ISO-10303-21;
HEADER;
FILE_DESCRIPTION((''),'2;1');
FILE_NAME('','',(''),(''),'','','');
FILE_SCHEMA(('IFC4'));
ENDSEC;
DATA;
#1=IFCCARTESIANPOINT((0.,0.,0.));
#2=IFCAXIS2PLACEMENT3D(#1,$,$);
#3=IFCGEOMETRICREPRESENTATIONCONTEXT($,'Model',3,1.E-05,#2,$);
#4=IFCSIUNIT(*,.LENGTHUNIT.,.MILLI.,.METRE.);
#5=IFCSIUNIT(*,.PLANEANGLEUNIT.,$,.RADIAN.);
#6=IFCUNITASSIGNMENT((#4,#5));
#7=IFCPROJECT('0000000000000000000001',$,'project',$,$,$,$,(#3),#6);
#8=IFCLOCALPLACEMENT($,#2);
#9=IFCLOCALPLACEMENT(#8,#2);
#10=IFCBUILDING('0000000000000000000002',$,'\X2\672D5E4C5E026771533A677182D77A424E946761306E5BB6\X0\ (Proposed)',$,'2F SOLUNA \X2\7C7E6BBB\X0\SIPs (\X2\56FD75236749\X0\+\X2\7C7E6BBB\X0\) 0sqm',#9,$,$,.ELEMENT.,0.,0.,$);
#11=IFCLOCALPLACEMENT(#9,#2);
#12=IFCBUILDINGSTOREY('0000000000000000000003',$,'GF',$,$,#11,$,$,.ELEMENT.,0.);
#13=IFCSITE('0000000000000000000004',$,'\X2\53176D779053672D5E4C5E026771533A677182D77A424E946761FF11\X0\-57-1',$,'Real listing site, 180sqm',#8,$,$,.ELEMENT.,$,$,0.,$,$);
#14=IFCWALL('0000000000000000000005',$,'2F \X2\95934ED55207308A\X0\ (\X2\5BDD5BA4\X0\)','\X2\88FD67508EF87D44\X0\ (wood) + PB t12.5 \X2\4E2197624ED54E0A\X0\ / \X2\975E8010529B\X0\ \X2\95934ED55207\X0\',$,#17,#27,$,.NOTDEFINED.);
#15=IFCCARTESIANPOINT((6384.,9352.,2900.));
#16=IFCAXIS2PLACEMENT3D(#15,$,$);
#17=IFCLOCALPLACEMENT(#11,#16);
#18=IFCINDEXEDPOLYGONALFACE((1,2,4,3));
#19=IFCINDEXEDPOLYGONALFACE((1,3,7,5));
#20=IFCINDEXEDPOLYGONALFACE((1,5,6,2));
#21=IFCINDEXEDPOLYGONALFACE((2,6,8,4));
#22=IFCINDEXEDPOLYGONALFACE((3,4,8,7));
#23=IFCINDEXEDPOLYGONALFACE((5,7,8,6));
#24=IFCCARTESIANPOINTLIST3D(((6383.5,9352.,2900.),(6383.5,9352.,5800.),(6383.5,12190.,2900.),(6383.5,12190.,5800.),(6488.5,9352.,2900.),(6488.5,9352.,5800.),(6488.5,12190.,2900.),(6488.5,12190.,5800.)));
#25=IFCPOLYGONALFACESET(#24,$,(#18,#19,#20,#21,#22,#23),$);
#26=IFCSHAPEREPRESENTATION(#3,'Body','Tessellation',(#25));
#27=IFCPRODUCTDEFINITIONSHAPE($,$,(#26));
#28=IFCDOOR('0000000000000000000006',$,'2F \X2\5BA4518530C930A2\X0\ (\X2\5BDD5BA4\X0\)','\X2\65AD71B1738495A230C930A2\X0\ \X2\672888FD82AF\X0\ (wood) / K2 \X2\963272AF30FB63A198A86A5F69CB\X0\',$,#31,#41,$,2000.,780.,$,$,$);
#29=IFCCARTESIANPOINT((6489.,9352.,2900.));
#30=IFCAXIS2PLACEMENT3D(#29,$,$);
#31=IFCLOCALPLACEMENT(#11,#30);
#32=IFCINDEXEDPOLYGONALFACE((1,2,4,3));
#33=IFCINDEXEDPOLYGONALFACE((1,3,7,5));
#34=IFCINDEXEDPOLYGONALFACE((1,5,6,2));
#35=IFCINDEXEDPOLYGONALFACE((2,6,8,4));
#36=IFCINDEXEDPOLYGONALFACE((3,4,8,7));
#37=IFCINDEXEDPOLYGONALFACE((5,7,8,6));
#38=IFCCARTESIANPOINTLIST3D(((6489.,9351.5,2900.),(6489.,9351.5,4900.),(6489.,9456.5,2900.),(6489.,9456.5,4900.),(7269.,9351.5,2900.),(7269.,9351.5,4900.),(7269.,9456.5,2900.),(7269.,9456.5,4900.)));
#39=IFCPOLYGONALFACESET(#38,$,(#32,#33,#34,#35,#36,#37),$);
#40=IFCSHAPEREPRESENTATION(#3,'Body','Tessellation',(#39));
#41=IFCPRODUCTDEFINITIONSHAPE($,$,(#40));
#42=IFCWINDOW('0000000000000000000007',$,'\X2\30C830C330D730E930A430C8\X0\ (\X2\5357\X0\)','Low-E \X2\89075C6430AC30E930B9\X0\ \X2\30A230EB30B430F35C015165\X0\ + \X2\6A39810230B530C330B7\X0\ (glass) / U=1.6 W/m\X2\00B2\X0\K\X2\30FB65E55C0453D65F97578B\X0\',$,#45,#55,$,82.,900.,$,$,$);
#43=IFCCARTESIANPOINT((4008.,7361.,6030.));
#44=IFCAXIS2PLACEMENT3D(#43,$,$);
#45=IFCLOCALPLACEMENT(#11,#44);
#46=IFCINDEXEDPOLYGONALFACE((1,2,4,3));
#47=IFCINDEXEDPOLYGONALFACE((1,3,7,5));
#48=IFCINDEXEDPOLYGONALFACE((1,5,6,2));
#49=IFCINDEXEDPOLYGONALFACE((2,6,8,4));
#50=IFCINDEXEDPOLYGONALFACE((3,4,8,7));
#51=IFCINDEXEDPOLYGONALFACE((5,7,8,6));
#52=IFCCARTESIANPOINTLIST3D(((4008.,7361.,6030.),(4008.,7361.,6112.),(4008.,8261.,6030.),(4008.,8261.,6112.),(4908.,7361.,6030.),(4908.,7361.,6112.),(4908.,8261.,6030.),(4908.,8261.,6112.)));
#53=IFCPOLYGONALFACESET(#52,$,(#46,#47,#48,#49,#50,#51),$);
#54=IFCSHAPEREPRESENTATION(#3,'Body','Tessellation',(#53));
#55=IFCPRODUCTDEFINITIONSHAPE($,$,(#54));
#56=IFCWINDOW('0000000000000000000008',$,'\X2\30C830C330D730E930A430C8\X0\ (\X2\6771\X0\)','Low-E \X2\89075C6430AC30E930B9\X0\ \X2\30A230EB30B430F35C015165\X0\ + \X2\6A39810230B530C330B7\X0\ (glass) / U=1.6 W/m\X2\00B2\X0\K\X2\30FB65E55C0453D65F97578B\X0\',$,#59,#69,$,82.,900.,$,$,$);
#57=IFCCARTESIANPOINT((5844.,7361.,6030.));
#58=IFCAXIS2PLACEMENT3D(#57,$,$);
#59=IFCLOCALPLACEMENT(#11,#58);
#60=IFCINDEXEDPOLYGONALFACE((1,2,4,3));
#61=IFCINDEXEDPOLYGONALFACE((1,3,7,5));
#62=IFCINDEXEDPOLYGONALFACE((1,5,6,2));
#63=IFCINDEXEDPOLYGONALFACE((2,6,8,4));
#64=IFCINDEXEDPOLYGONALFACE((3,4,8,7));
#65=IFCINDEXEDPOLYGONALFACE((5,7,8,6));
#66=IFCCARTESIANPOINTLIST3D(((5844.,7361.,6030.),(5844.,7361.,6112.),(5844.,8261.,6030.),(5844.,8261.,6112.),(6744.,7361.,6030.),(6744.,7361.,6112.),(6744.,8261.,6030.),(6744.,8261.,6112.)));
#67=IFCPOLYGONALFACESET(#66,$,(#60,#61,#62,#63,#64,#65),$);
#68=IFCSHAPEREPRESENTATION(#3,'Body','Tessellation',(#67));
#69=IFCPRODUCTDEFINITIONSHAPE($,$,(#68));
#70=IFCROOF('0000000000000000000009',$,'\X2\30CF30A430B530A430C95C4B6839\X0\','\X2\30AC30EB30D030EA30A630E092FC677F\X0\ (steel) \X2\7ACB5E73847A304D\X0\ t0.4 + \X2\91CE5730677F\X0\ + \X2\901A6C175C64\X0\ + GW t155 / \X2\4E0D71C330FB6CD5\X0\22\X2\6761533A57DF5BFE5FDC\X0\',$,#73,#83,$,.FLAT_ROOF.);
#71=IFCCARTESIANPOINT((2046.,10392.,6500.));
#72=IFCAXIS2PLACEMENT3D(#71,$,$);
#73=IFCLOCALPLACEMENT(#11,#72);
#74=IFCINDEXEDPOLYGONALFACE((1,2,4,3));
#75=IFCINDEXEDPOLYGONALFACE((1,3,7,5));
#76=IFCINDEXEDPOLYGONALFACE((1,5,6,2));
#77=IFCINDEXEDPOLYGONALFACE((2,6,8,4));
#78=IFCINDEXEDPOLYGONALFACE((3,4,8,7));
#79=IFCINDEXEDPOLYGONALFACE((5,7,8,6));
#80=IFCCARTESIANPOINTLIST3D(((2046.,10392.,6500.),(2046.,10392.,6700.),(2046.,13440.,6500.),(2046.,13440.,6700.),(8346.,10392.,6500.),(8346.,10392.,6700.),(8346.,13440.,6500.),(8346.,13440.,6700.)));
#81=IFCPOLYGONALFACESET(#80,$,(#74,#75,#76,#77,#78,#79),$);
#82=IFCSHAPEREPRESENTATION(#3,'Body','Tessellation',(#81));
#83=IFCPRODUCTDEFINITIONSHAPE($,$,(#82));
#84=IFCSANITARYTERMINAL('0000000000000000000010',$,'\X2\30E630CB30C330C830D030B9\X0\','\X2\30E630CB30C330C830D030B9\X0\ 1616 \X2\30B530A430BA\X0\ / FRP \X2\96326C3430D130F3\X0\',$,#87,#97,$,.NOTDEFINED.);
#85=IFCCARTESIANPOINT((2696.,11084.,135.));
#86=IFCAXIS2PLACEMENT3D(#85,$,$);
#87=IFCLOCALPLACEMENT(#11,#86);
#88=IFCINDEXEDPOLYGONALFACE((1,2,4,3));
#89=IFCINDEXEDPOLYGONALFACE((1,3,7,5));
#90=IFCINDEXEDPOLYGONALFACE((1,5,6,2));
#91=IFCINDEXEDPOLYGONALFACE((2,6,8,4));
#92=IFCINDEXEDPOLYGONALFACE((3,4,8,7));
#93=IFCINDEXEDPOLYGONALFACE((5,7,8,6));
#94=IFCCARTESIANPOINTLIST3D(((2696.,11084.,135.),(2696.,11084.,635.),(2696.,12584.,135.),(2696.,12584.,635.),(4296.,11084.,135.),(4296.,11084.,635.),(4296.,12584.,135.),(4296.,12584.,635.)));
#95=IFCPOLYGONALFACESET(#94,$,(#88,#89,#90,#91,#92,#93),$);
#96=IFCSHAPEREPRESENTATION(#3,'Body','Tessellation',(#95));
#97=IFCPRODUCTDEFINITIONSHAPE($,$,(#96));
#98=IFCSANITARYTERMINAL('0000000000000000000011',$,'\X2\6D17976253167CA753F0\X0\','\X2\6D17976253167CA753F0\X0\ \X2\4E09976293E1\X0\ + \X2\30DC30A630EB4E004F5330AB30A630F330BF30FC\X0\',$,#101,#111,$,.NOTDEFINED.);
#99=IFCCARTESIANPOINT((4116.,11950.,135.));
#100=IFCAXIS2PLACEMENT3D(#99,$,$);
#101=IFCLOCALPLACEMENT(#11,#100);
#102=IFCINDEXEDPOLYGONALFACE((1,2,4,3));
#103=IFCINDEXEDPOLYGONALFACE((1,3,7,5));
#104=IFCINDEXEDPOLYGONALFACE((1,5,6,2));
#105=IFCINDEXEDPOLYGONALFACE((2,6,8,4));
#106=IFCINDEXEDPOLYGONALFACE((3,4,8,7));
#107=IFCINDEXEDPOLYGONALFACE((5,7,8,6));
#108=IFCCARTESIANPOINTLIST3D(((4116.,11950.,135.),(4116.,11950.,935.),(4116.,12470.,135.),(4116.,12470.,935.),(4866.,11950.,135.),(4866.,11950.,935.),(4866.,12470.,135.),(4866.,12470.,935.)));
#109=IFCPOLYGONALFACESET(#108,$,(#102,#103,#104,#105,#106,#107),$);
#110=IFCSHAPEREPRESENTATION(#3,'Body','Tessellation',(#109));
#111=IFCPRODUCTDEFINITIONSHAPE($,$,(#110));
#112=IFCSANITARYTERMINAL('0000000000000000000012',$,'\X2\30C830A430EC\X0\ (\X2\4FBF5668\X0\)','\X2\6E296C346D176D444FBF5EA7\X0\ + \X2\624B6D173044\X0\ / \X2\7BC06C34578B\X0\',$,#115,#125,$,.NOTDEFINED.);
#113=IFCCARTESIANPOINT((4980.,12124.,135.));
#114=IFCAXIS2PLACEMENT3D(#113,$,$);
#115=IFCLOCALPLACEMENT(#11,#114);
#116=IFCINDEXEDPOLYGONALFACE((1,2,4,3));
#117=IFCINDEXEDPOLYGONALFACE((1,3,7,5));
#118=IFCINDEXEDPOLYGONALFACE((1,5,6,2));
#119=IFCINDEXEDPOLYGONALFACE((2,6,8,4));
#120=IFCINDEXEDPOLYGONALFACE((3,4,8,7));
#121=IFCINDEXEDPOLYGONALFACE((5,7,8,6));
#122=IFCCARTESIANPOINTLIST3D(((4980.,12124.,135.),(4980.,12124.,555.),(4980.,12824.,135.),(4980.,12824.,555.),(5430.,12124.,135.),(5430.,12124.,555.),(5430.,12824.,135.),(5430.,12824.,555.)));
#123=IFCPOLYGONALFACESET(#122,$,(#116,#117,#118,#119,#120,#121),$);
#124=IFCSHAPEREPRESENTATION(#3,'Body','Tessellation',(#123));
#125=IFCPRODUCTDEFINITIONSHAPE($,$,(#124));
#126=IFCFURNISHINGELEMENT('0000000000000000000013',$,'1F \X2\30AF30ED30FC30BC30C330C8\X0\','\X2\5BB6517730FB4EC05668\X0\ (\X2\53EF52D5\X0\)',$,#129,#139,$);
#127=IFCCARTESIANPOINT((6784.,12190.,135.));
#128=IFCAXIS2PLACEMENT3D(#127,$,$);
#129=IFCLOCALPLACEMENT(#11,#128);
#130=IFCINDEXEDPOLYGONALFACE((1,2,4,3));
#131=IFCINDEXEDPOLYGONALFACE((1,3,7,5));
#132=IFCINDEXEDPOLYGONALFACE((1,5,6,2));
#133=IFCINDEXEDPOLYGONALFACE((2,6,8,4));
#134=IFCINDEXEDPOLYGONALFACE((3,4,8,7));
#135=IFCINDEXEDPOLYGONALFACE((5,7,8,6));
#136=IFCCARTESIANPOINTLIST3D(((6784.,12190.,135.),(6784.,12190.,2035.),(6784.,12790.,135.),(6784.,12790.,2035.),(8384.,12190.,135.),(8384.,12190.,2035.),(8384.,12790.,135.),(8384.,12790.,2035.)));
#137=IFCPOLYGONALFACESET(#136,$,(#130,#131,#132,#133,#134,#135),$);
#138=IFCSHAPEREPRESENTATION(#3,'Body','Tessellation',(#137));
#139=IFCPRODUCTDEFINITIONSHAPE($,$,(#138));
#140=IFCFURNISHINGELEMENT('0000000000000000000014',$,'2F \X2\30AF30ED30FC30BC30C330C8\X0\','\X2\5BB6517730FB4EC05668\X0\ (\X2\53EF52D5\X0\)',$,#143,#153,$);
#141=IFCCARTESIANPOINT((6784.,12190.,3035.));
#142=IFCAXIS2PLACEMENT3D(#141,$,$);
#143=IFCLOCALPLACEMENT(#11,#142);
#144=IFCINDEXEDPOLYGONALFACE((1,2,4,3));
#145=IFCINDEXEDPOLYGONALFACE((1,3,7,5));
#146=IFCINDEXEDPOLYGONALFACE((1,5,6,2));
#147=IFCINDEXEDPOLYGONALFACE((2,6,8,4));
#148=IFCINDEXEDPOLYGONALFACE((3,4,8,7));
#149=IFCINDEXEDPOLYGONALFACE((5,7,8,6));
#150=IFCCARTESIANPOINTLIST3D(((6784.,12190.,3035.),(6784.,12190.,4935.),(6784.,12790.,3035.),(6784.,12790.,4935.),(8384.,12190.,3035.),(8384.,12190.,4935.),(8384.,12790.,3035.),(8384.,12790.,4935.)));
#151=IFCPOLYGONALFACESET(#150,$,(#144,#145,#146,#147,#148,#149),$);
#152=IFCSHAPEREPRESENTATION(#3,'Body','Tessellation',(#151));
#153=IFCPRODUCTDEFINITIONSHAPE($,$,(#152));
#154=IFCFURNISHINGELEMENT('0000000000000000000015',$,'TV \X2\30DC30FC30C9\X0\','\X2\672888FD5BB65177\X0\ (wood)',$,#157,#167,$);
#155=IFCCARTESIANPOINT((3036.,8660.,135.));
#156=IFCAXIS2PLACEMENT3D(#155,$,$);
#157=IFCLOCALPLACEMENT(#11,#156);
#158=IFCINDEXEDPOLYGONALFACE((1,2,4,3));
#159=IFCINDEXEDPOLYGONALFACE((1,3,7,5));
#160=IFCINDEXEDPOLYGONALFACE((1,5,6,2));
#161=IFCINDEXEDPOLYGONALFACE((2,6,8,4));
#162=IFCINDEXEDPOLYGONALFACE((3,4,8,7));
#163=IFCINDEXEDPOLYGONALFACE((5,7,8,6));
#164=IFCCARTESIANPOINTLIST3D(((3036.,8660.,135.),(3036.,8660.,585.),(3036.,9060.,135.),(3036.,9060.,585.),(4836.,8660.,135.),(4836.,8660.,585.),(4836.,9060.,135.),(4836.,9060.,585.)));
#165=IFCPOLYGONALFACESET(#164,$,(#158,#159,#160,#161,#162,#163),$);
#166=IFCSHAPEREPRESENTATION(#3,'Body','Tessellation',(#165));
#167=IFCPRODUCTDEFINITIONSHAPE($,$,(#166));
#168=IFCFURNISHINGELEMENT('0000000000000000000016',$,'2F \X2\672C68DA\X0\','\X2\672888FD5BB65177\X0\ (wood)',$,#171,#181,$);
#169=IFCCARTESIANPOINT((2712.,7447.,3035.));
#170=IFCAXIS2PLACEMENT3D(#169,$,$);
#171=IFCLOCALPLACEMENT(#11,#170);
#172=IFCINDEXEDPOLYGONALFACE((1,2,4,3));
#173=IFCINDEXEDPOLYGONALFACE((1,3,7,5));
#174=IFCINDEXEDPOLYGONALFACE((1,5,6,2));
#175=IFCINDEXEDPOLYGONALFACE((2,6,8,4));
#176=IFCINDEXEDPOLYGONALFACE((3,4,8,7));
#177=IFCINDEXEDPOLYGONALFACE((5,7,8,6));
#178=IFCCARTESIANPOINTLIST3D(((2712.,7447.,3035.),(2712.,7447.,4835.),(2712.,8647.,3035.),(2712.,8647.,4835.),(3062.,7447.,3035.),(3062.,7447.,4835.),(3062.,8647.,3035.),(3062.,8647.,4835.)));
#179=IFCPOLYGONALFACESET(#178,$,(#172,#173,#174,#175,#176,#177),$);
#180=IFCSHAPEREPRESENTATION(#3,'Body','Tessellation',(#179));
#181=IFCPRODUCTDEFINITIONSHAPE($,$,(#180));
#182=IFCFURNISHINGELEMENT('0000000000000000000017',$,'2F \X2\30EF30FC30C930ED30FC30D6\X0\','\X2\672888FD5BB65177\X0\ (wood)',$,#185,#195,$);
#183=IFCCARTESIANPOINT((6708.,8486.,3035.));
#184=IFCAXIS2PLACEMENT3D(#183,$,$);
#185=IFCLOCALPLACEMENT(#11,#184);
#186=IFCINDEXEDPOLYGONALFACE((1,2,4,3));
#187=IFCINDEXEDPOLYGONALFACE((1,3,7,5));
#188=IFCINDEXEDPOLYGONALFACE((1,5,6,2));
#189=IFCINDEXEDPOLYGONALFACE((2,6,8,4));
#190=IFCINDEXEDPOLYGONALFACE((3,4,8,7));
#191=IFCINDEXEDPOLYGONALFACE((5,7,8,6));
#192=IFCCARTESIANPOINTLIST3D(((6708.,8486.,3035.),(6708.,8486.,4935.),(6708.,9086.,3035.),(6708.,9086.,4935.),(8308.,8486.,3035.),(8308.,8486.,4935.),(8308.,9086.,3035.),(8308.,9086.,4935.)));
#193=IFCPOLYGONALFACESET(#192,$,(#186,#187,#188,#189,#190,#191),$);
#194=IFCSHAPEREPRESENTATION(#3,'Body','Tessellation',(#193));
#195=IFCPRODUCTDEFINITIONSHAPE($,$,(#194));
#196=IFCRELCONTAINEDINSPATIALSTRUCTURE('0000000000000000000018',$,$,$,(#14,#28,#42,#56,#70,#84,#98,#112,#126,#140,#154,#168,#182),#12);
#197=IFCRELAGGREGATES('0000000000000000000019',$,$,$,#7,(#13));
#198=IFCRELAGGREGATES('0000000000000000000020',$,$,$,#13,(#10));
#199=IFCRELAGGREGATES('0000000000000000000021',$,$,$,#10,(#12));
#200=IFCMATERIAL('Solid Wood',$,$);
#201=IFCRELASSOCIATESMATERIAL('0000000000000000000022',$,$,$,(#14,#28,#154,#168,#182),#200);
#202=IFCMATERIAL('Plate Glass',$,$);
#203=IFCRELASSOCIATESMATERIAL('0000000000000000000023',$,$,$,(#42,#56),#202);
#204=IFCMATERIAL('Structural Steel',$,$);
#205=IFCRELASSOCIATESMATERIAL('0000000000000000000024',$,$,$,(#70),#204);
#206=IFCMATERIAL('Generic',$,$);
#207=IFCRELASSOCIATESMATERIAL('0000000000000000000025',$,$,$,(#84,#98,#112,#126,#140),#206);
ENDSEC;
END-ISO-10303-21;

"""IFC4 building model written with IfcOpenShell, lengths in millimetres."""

from ifc_helpers import new_model, si_unit, frame, frame_2d, origin, place, context, project, spatial, rectangle, extrude, material, element, save


model = new_model("IFC4")

# Units and contexts
model_context = context("Model", 3, precision=1e-05, world=origin())
ifc_project = project(units=[si_unit("LENGTHUNIT", "METRE", prefix="MILLI"), si_unit("PLANEANGLEUNIT", "RADIAN")], contexts=[model_context])

# Site, building, storey
site_placement = place(None, origin())
site = spatial("IfcSite", under=ifc_project, at=site_placement, Name="北海道札幌市東区東苗穂五条１-57-1", ObjectType="Real listing site, 180sqm", CompositionType="ELEMENT", RefElevation=0.0)
building_placement = place(site_placement, origin())
building = spatial("IfcBuilding", under=site, at=building_placement, Name="札幌市東区東苗穂五条の家 (Proposed)", ObjectType="2F SOLUNA 籾殻SIPs (国産杉+籾殻) 0sqm", CompositionType="ELEMENT", ElevationOfRefHeight=0.0, ElevationOfTerrain=0.0)
storey_placement = place(building_placement, origin())
storey = spatial("IfcBuildingStorey", under=building, at=storey_placement, Name="GF", CompositionType="ELEMENT", Elevation=0.0)

# Shared definitions
ifc_material_1 = material(Name="Solid Wood")
ifc_material_2 = material(Name="Plate Glass")

# Wall
wall_1_placement = place(storey_placement, frame((6384.0, 9352.0, 2900.0)))
element("IfcWall", 1, at=wall_1_placement, inside=storey, material=ifc_material_1, Name="2F 間仕切り (寝室)", Description="製材軸組 (wood) + PB t12.5 両面仕上 / 非耐力 間仕切", PredefinedType="NOTDEFINED", context=model_context, shape_type="SweptSolid", body=[
    extrude(rectangle(XDim=105.0, YDim=2838.0, at=frame_2d((52.0, 1419.0))), frame((6384.0, 9352.0, 2900.0)), (0.0, 0.0, 1.0), 2900.0),
])

# Door
door_1_placement = place(storey_placement, frame((6489.0, 9352.0, 2900.0)))
element("IfcDoor", 2, at=door_1_placement, inside=storey, material=ifc_material_1, Name="2F 室内ドア (寝室)", Description="断熱玄関ドア 木製芯 (wood) / K2 防犯・採風機構", OverallHeight=2000.0, OverallWidth=780.0, context=model_context, shape_type="SweptSolid", body=[
    extrude(rectangle(XDim=780.0, YDim=105.0, at=frame_2d((390.0, 52.0))), frame((6489.0, 9352.0, 2900.0)), (0.0, 0.0, 1.0), 2000.0),
])

# Windows
window_1_placement = place(storey_placement, frame((4008.0, 7361.0, 6030.0)))
element("IfcWindow", 3, at=window_1_placement, inside=storey, material=ifc_material_2, Name="トップライト (南)", Description="Low-E 複層ガラス アルゴン封入 + 樹脂サッシ (glass) / U=1.6 W/m²K・日射取得型", OverallHeight=82.0, OverallWidth=900.0, context=model_context, shape_type="SweptSolid", body=[
    extrude(rectangle(XDim=900.0, YDim=900.0, at=frame_2d((450.0, 450.0))), frame((4008.0, 7361.0, 6030.0)), (0.0, 0.0, 1.0), 82.0),
])
window_2_placement = place(storey_placement, frame((5844.0, 7361.0, 6030.0)))
element("IfcWindow", 4, at=window_2_placement, inside=storey, material=ifc_material_2, Name="トップライト (東)", Description="Low-E 複層ガラス アルゴン封入 + 樹脂サッシ (glass) / U=1.6 W/m²K・日射取得型", OverallHeight=82.0, OverallWidth=900.0, context=model_context, shape_type="SweptSolid", body=[
    extrude(rectangle(XDim=900.0, YDim=900.0, at=frame_2d((450.0, 450.0))), frame((5844.0, 7361.0, 6030.0)), (0.0, 0.0, 1.0), 82.0),
])

# Roof
ifc_material_3 = material(Name="Structural Steel")
roof_placement = place(storey_placement, frame((2046.0, 10392.0, 6500.0)))
element("IfcRoof", 5, at=roof_placement, inside=storey, material=ifc_material_3, Name="ハイサイド屋根", Description="ガルバリウム鋼板 (steel) 立平葺き t0.4 + 野地板 + 通気層 + GW t155 / 不燃・法22条区域対応", PredefinedType="FLAT_ROOF", context=model_context, shape_type="SweptSolid", body=[
    extrude(rectangle(XDim=6300.0, YDim=3048.0, at=frame_2d((3150.0, 1524.0))), frame((2046.0, 10392.0, 6500.0)), (0.0, 0.0, 1.0), 200.0),
])

# Sanitary terminals
ifc_material_4 = material(Name="Generic")
sanitary_terminal_1_placement = place(storey_placement, frame((2696.0, 11084.0, 135.0)))
element("IfcSanitaryTerminal", 6, at=sanitary_terminal_1_placement, inside=storey, material=ifc_material_4, Name="ユニットバス", Description="ユニットバス 1616 サイズ / FRP 防水パン", PredefinedType="NOTDEFINED", context=model_context, shape_type="SweptSolid", body=[
    extrude(rectangle(XDim=1600.0, YDim=1500.0, at=frame_2d((800.0, 750.0))), frame((2696.0, 11084.0, 135.0)), (0.0, 0.0, 1.0), 500.0),
])
sanitary_terminal_2_placement = place(storey_placement, frame((4116.0, 11950.0, 135.0)))
element("IfcSanitaryTerminal", 7, at=sanitary_terminal_2_placement, inside=storey, material=ifc_material_4, Name="洗面化粧台", Description="洗面化粧台 三面鏡 + ボウル一体カウンター", PredefinedType="NOTDEFINED", context=model_context, shape_type="SweptSolid", body=[
    extrude(rectangle(XDim=750.0, YDim=520.0, at=frame_2d((375.0, 260.0))), frame((4116.0, 11950.0, 135.0)), (0.0, 0.0, 1.0), 800.0),
])
sanitary_terminal_3_placement = place(storey_placement, frame((4980.0, 12124.0, 135.0)))
element("IfcSanitaryTerminal", 8, at=sanitary_terminal_3_placement, inside=storey, material=ifc_material_4, Name="トイレ (便器)", Description="温水洗浄便座 + 手洗い / 節水型", PredefinedType="NOTDEFINED", context=model_context, shape_type="SweptSolid", body=[
    extrude(rectangle(XDim=450.0, YDim=700.0, at=frame_2d((225.0, 350.0))), frame((4980.0, 12124.0, 135.0)), (0.0, 0.0, 1.0), 420.0),
])

# Furnishing elements
furnishing_1_placement = place(storey_placement, frame((6784.0, 12190.0, 135.0)))
element("IfcFurnishingElement", 9, at=furnishing_1_placement, inside=storey, material=ifc_material_4, Name="1F クローゼット", Description="家具・什器 (可動)", context=model_context, shape_type="SweptSolid", body=[
    extrude(rectangle(XDim=1600.0, YDim=600.0, at=frame_2d((800.0, 300.0))), frame((6784.0, 12190.0, 135.0)), (0.0, 0.0, 1.0), 1900.0),
])
furnishing_2_placement = place(storey_placement, frame((6784.0, 12190.0, 3035.0)))
element("IfcFurnishingElement", 10, at=furnishing_2_placement, inside=storey, material=ifc_material_4, Name="2F クローゼット", Description="家具・什器 (可動)", context=model_context, shape_type="SweptSolid", body=[
    extrude(rectangle(XDim=1600.0, YDim=600.0, at=frame_2d((800.0, 300.0))), frame((6784.0, 12190.0, 3035.0)), (0.0, 0.0, 1.0), 1900.0),
])
furnishing_3_placement = place(storey_placement, frame((3036.0, 8660.0, 135.0)))
element("IfcFurnishingElement", 11, at=furnishing_3_placement, inside=storey, material=ifc_material_1, Name="TV ボード", Description="木製家具 (wood)", context=model_context, shape_type="SweptSolid", body=[
    extrude(rectangle(XDim=1800.0, YDim=400.0, at=frame_2d((900.0, 200.0))), frame((3036.0, 8660.0, 135.0)), (0.0, 0.0, 1.0), 450.0),
])
furnishing_4_placement = place(storey_placement, frame((2712.0, 7447.0, 3035.0)))
element("IfcFurnishingElement", 12, at=furnishing_4_placement, inside=storey, material=ifc_material_1, Name="2F 本棚", Description="木製家具 (wood)", context=model_context, shape_type="SweptSolid", body=[
    extrude(rectangle(XDim=350.0, YDim=1200.0, at=frame_2d((175.0, 600.0))), frame((2712.0, 7447.0, 3035.0)), (0.0, 0.0, 1.0), 1800.0),
])
furnishing_5_placement = place(storey_placement, frame((6708.0, 8486.0, 3035.0)))
element("IfcFurnishingElement", 13, at=furnishing_5_placement, inside=storey, material=ifc_material_1, Name="2F ワードローブ", Description="木製家具 (wood)", context=model_context, shape_type="SweptSolid", body=[
    extrude(rectangle(XDim=1600.0, YDim=600.0, at=frame_2d((800.0, 300.0))), frame((6708.0, 8486.0, 3035.0)), (0.0, 0.0, 1.0), 1900.0),
])

save(model, "model.ifc")
